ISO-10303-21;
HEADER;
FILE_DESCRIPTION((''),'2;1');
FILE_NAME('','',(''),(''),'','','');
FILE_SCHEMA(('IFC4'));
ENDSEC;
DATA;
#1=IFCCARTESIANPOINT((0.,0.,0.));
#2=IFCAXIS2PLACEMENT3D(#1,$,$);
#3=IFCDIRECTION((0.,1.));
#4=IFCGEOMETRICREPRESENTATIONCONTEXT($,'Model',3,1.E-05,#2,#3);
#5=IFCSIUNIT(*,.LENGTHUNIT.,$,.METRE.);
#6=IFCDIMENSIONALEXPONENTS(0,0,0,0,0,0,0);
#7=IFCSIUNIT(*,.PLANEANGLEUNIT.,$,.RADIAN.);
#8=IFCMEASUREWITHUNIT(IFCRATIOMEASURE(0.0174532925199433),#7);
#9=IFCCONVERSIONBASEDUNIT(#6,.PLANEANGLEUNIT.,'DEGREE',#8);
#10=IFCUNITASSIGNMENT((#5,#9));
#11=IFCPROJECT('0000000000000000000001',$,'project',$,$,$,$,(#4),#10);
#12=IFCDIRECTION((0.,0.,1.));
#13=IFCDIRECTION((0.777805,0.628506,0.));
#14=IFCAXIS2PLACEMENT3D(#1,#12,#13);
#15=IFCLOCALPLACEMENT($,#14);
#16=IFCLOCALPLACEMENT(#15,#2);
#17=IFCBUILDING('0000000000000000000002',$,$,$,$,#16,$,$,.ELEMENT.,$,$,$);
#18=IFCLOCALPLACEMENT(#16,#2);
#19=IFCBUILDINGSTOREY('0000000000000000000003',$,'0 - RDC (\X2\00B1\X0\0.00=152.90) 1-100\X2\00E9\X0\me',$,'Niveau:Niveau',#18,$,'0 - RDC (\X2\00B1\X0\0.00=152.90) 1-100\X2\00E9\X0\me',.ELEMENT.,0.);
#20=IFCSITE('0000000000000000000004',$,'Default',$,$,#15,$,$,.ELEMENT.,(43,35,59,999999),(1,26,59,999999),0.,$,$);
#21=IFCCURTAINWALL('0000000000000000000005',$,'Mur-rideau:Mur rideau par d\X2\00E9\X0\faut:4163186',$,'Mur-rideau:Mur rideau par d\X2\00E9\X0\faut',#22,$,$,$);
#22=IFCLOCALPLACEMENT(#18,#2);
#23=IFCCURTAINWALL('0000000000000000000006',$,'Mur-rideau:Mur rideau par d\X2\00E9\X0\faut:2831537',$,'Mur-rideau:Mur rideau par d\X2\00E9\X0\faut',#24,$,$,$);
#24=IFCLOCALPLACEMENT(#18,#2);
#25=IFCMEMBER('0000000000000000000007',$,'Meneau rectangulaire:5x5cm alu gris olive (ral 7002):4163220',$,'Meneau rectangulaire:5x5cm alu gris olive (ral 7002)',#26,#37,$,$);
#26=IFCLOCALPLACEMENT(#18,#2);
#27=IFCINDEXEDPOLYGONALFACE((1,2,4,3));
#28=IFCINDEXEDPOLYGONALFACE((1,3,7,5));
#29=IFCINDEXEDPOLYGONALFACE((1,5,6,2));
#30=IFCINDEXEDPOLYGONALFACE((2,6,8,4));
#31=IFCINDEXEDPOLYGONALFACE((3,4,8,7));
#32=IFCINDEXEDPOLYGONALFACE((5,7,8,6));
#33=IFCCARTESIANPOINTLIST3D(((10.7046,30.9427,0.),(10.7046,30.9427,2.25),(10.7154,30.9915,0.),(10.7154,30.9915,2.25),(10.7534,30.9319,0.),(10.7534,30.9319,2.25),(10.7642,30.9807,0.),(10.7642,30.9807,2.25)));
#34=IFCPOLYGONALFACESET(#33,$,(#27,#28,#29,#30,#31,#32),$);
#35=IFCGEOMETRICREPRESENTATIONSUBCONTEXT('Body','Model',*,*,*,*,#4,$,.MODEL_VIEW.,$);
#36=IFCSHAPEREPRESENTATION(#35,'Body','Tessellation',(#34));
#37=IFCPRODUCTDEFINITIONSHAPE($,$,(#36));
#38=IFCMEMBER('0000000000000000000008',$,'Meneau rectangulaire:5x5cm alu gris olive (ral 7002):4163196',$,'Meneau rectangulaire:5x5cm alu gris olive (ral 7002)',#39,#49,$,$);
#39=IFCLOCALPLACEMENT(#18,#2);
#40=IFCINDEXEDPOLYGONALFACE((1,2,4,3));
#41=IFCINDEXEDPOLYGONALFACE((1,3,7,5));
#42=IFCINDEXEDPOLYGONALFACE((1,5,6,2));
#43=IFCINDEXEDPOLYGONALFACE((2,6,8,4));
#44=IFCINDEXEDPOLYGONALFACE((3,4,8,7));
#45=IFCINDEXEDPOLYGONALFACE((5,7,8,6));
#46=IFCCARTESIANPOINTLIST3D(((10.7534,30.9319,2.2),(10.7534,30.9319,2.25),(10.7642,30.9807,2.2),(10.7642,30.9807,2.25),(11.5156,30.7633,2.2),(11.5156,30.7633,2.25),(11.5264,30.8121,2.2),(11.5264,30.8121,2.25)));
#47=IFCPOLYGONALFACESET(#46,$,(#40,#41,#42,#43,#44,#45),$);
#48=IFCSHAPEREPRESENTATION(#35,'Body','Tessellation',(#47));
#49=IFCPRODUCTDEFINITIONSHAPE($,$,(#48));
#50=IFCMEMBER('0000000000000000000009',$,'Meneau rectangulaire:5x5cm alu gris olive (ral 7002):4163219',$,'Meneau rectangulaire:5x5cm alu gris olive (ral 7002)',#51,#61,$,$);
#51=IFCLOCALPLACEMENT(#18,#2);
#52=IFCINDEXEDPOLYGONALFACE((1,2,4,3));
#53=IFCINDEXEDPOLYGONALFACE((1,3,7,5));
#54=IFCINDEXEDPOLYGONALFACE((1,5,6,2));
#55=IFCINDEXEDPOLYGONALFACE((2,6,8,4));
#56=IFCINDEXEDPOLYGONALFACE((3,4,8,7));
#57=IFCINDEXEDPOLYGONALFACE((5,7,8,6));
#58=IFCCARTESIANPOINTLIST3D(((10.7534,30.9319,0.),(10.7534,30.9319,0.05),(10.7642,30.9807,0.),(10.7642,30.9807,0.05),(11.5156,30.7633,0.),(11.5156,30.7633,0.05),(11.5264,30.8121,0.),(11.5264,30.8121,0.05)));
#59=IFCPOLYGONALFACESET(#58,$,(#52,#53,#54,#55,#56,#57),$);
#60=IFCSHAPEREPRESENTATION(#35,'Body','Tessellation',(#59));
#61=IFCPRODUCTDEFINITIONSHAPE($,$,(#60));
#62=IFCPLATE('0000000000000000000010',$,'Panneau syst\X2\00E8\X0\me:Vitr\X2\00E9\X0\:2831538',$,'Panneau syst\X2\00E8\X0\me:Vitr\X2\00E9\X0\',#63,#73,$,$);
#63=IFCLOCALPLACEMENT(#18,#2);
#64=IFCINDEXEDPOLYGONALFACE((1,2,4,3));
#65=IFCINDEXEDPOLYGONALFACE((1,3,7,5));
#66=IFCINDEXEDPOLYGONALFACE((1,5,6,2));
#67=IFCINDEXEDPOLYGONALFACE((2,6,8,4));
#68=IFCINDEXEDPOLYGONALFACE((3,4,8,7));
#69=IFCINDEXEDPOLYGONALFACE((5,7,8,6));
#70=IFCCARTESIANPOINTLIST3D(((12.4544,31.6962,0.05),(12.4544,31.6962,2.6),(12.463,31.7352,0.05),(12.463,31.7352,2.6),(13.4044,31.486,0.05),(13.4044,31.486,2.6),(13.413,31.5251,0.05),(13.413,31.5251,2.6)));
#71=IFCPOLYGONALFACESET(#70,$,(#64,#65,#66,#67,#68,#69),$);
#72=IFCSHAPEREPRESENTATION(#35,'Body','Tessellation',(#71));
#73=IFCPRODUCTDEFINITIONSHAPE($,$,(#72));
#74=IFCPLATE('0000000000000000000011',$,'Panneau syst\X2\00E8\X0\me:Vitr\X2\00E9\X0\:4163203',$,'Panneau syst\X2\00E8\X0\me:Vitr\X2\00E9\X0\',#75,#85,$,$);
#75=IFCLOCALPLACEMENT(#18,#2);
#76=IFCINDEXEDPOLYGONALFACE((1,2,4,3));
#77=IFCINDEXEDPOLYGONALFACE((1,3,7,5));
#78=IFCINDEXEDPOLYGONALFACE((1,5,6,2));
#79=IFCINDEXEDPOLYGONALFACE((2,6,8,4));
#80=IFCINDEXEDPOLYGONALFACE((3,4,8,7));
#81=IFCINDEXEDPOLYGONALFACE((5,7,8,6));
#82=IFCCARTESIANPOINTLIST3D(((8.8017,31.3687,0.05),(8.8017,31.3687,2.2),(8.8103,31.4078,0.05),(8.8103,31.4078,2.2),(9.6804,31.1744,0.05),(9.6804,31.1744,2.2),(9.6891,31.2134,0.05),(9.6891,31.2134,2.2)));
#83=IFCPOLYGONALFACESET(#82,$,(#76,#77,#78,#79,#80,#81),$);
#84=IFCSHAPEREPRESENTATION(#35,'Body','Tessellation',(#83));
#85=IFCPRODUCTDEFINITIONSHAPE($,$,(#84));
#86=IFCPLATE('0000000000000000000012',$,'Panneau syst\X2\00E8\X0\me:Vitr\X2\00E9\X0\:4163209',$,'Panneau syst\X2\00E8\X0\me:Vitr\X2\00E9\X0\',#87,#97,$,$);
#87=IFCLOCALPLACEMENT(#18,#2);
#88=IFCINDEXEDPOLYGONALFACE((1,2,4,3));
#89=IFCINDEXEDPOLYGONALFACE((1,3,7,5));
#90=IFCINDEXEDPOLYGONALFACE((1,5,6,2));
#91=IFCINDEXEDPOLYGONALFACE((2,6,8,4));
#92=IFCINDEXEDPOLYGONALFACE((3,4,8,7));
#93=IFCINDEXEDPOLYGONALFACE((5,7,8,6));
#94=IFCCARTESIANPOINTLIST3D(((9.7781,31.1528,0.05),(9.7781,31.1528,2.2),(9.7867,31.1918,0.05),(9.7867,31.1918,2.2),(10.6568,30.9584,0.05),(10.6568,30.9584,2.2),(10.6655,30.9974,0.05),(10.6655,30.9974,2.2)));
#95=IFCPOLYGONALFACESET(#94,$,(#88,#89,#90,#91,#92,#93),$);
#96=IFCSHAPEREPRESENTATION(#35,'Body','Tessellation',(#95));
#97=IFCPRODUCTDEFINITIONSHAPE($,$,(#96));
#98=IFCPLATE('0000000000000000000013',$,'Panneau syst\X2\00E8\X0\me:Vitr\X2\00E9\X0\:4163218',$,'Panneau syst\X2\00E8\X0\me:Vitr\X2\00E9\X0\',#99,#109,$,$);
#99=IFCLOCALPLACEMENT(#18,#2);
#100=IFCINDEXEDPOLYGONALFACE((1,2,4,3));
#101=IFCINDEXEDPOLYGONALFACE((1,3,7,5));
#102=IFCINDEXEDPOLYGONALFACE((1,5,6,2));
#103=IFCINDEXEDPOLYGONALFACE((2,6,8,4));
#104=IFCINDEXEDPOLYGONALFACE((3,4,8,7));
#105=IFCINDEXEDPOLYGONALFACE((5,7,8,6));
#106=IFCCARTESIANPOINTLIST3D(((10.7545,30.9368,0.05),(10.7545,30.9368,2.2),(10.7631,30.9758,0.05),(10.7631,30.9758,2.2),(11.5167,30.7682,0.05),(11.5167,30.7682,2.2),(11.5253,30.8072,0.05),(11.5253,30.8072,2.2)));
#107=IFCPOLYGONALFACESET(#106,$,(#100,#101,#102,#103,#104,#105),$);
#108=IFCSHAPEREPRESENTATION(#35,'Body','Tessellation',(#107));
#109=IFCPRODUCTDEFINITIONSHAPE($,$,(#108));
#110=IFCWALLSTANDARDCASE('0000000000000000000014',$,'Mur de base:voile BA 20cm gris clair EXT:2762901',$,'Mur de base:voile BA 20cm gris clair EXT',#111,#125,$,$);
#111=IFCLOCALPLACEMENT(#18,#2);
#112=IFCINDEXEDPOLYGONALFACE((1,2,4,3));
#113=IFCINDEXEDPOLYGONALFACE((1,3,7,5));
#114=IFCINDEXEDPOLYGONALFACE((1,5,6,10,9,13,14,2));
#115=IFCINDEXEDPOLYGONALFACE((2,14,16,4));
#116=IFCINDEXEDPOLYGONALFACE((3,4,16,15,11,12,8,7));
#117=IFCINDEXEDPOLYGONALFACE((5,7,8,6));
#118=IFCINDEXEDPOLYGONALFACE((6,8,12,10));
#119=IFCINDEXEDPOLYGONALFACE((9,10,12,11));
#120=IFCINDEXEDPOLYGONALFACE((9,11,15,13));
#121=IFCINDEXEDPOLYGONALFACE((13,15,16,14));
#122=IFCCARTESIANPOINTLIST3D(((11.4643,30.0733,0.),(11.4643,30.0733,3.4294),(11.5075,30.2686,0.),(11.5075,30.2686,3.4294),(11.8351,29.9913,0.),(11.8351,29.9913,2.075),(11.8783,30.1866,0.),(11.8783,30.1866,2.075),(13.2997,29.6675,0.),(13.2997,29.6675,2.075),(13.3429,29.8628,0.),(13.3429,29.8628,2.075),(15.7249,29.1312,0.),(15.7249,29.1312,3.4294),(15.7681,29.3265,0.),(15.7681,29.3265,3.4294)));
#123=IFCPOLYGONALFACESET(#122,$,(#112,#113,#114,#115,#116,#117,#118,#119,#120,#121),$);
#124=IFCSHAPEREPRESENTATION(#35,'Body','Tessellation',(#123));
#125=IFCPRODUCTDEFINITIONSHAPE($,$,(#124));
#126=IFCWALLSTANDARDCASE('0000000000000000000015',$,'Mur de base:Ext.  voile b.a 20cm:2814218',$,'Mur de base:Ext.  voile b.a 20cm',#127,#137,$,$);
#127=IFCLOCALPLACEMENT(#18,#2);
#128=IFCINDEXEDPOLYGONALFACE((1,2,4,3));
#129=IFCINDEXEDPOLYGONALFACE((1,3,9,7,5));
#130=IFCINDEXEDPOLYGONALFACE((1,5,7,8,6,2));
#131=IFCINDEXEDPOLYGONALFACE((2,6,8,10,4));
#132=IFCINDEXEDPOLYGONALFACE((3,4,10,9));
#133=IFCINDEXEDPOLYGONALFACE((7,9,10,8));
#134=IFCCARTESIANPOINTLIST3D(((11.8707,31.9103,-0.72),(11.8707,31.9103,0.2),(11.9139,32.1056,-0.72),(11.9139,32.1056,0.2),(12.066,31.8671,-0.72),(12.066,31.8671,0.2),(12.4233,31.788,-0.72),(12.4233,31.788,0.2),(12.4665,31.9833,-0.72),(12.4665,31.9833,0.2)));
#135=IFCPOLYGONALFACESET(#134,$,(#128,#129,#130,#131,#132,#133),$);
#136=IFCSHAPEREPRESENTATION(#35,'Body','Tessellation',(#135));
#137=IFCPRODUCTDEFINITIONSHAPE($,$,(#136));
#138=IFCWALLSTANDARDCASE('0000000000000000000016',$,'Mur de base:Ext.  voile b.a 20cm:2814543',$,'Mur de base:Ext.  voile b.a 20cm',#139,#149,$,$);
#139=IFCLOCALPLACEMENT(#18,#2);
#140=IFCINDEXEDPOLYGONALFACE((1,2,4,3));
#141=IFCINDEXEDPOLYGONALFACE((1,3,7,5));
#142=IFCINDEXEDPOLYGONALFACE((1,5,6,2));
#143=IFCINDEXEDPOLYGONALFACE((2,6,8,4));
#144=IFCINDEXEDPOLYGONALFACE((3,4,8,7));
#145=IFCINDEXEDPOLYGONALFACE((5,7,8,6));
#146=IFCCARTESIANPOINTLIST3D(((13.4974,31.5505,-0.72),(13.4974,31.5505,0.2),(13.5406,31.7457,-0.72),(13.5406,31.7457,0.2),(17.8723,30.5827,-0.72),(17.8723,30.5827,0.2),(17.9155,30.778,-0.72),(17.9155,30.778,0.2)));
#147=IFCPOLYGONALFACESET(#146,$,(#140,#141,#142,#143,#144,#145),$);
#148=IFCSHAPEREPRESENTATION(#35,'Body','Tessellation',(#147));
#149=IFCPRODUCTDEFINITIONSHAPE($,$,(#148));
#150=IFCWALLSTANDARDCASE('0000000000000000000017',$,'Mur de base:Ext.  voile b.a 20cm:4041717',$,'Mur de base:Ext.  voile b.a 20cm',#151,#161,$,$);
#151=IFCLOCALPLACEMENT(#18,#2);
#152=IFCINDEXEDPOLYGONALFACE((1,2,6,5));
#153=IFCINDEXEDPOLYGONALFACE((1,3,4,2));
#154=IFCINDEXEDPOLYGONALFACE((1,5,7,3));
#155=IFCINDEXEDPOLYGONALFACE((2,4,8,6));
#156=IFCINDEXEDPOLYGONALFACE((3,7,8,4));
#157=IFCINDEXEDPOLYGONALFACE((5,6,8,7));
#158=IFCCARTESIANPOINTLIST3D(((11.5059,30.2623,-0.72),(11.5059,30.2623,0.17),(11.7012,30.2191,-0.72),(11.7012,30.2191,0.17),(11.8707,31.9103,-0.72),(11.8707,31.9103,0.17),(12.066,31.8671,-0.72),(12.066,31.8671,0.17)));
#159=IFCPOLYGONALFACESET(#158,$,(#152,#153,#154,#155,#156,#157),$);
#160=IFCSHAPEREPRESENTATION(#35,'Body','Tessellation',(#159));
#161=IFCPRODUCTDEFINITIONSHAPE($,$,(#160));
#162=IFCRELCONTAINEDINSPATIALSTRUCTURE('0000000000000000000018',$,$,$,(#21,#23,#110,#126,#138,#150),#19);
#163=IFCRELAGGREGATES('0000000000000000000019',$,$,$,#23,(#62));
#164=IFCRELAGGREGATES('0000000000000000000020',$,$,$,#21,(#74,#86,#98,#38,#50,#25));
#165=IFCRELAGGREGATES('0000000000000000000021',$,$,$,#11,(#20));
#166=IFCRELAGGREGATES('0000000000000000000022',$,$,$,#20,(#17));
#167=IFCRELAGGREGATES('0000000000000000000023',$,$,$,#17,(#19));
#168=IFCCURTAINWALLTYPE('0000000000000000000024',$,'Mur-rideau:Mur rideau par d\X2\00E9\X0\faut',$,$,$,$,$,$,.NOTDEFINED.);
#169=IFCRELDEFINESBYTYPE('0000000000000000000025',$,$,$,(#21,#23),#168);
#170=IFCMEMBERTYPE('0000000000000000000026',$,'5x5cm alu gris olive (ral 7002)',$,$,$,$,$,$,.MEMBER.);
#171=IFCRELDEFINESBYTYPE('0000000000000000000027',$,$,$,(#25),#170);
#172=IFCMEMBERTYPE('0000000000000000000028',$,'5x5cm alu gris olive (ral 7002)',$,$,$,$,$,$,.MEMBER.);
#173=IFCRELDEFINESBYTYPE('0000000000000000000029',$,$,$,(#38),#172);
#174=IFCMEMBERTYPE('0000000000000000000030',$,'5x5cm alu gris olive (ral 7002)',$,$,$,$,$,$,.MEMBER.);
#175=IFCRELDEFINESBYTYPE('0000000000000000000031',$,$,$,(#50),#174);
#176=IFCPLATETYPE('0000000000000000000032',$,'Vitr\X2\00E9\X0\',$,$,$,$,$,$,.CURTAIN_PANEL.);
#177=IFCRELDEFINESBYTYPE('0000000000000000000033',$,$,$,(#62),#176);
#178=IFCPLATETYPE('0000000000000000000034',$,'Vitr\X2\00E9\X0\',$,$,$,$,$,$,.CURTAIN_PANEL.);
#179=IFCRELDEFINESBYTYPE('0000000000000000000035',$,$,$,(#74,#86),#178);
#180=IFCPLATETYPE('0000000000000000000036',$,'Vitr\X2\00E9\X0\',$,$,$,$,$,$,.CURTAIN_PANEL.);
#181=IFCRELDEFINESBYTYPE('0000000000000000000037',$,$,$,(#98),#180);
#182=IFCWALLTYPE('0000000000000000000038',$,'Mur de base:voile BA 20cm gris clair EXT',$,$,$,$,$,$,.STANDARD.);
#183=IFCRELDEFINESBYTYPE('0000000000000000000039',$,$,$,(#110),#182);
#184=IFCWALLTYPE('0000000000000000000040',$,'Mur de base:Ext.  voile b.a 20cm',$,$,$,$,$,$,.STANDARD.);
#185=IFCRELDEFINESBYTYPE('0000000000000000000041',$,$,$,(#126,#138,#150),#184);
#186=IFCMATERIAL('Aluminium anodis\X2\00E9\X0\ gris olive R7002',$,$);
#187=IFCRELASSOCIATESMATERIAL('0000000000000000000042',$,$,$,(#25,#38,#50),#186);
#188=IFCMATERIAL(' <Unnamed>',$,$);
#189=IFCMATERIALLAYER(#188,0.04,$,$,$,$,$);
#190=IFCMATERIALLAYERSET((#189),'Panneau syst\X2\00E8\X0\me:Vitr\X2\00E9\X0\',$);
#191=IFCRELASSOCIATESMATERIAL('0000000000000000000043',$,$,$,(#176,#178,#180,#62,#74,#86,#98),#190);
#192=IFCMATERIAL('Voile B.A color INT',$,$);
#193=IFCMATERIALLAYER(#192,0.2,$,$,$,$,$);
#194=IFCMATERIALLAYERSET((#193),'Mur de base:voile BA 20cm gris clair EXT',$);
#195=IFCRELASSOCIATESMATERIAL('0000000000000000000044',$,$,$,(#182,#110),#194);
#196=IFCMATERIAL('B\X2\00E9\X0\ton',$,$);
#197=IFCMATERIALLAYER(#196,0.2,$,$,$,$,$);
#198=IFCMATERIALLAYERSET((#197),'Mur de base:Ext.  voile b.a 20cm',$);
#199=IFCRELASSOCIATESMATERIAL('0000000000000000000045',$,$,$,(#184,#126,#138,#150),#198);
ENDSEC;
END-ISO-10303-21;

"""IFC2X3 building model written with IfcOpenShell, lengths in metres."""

from ifc_helpers import new_model, entity, si_unit, converted_unit, direction, frame, frame_2d, origin, origin_2d_with_axis, place, context, subcontext, project, spatial, polyline, rectangle, outline, extrude, source, transform, mapped, material, layer, layer_set, layer_usage, type_object, type_shapes, element, aggregate, save


model = new_model("IFC2X3")

# Units and contexts
model_context = context("Model", 3, precision=1e-05, world=origin(), true_north=direction((0.0, 1.0)))
body_context = subcontext(model_context, "Body", "Model", "MODEL_VIEW")
ifc_project = project(units=[si_unit("LENGTHUNIT", "METRE"), converted_unit("PLANEANGLEUNIT", "DEGREE", entity("IfcRatioMeasure", 0.0174532925199433), si_unit("PLANEANGLEUNIT", "RADIAN"), dimensions=[0, 0, 0, 0, 0, 0, 0])], contexts=[model_context])

# Site, building, storey
site_placement = place(None, frame((0.0, 0.0, 0.0), z_axis=(0.0, 0.0, 1.0), x_axis=(0.777805, 0.628506, 0.0)))
site = spatial("IfcSite", under=ifc_project, at=site_placement, Name="Default", CompositionType="ELEMENT", RefLatitude=(43, 35, 59, 999999), RefLongitude=(1, 26, 59, 999999), RefElevation=0.0)
building_placement = place(site_placement, origin())
building = spatial("IfcBuilding", under=site, at=building_placement, CompositionType="ELEMENT")
storey_placement = place(building_placement, origin())
storey = spatial("IfcBuildingStorey", under=building, at=storey_placement, Name="0 - RDC (±0.00=152.90) 1-100éme", ObjectType="Niveau:Niveau", LongName="0 - RDC (±0.00=152.90) 1-100éme", CompositionType="ELEMENT", Elevation=0.0)

# Curtain walls
curtain_wall_type = type_object("IfcCurtainWallType", Name="Mur-rideau:Mur rideau par défaut", PredefinedType="NOTDEFINED")
curtain_wall_1_placement = place(storey_placement, origin())
curtain_wall_1 = element("IfcCurtainWall", 1, at=curtain_wall_1_placement, inside=storey, type_object=curtain_wall_type, Name="Mur-rideau:Mur rideau par défaut:4163186", ObjectType="Mur-rideau:Mur rideau par défaut")
ifc_material_1 = material(Name="Aluminium anodisé gris olive R7002")
curtain_wall_2_placement = place(storey_placement, origin())
curtain_wall_2 = element("IfcCurtainWall", 2, at=curtain_wall_2_placement, inside=storey, type_object=curtain_wall_type, Name="Mur-rideau:Mur rideau par défaut:2831537", ObjectType="Mur-rideau:Mur rideau par défaut")

# Members
member_type_1 = type_object("IfcMemberType", Name="5x5cm alu gris olive (ral 7002)", PredefinedType="MEMBER")
shared_shape_1 = source(origin(), body_context, "Body", "SweptSolid", [
    extrude(rectangle(XDim=0.05, YDim=0.05, at=origin_2d_with_axis()), frame((0.0, 0.0, -2.25), z_axis=(0.0, 0.0, 1.0), x_axis=(0.0, -1.0, 0.0)), (0.0, 0.0, 1.0), 2.25),
])
type_shapes(member_type_1, [shared_shape_1])
member_1_placement = place(storey_placement, frame((10.7344, 30.9617, 0.0), z_axis=(0.0, 0.0, -1.0), x_axis=(0.976397, -0.215985, 0.0)))
member_1 = element("IfcMember", 3, at=member_1_placement, type_object=member_type_1, material=ifc_material_1, Name="Meneau rectangulaire:5x5cm alu gris olive (ral 7002):4163220", ObjectType="Meneau rectangulaire:5x5cm alu gris olive (ral 7002)", context=body_context, shape_type="MappedRepresentation", body=[
    mapped(shared_shape_1, transform((0.0, 0.0, 0.0), scale=1.0)),
])
member_type_2 = type_object("IfcMemberType", Name="5x5cm alu gris olive (ral 7002)", PredefinedType="MEMBER")
shared_shape_2 = source(origin(), body_context, "Body", "SweptSolid", [
    extrude(rectangle(XDim=0.05, YDim=0.05, at=origin_2d_with_axis()), frame((-0.025, 0.0, -0.7806), z_axis=(0.0, 0.0, 1.0), x_axis=(0.0, -1.0, 0.0)), (0.0, 0.0, 1.0), 0.7806),
])
type_shapes(member_type_2, [shared_shape_2])
member_2_placement = place(storey_placement, frame((11.521, 30.7877, 2.25), z_axis=(0.976397, -0.215985, 0.0), x_axis=(0.0, 0.0, 1.0)))
member_2 = element("IfcMember", 4, at=member_2_placement, type_object=member_type_2, material=ifc_material_1, Name="Meneau rectangulaire:5x5cm alu gris olive (ral 7002):4163196", ObjectType="Meneau rectangulaire:5x5cm alu gris olive (ral 7002)", context=body_context, shape_type="MappedRepresentation", body=[
    mapped(shared_shape_2, transform((0.0, 0.0, 0.0), scale=1.0)),
])
member_type_3 = type_object("IfcMemberType", Name="5x5cm alu gris olive (ral 7002)", PredefinedType="MEMBER")
shared_shape_3 = source(origin(), body_context, "Body", "SweptSolid", [
    extrude(rectangle(XDim=0.05, YDim=0.05, at=origin_2d_with_axis()), frame((-0.025, 0.0, -0.7806), z_axis=(0.0, 0.0, 1.0), x_axis=(0.0, -1.0, 0.0)), (0.0, 0.0, 1.0), 0.7806),
])
type_shapes(member_type_3, [shared_shape_3])
member_3_placement = place(storey_placement, frame((10.7588, 30.9563, 0.0), z_axis=(-0.976397, 0.215985, 0.0), x_axis=(0.0, 0.0, -1.0)))
member_3 = element("IfcMember", 5, at=member_3_placement, type_object=member_type_3, material=ifc_material_1, Name="Meneau rectangulaire:5x5cm alu gris olive (ral 7002):4163219", ObjectType="Meneau rectangulaire:5x5cm alu gris olive (ral 7002)", context=body_context, shape_type="MappedRepresentation", body=[
    mapped(shared_shape_3, transform((0.0, 0.0, 0.0), scale=1.0)),
])

# Plates
ifc_material_2 = material(Name=" <Unnamed>")
ifc_layer_1 = layer(ifc_material_2, 0.04)
ifc_layer_set_1 = layer_set([ifc_layer_1], Name="Panneau système:Vitré")
ifc_layer_usage_1 = layer_usage(ifc_layer_set_1, "AXIS3", "POSITIVE", 0.0)
plate_type_1 = type_object("IfcPlateType", Name="Vitré", PredefinedType="CURTAIN_PANEL", material=ifc_layer_set_1)
shared_shape_4 = source(origin(), body_context, "Body", "SweptSolid", [
    extrude(rectangle(XDim=0.04, YDim=0.9729, at=frame_2d((0.0, 0.0), x_axis=(1.0, 0.0))), frame((0.0, 0.0, 0.0), z_axis=(0.0, 0.0, 1.0), x_axis=(0.0, 1.0, 0.0)), (0.0, 0.0, 1.0), 2.55),
])
type_shapes(plate_type_1, [shared_shape_4])
plate_1_placement = place(curtain_wall_2_placement, frame((12.9337, 31.6106, 0.05), z_axis=(0.0, 0.0, 1.0), x_axis=(0.976397, -0.215985, 0.0)))
plate_1 = element("IfcPlate", 6, at=plate_1_placement, type_object=plate_type_1, material=ifc_layer_usage_1, Name="Panneau système:Vitré:2831538", ObjectType="Panneau système:Vitré", context=body_context, shape_type="MappedRepresentation", body=[
    mapped(shared_shape_4, transform((0.0, 0.0, 0.0), scale=1.0)),
])
aggregate(curtain_wall_2, [plate_1])
ifc_layer_usage_2 = layer_usage(ifc_layer_set_1, "AXIS3", "POSITIVE", 0.0)
plate_type_2 = type_object("IfcPlateType", Name="Vitré", PredefinedType="CURTAIN_PANEL", material=ifc_layer_set_1)
shared_shape_5 = source(origin(), body_context, "Body", "SweptSolid", [
    extrude(rectangle(XDim=0.04, YDim=0.9, at=frame_2d((0.0, 0.0), x_axis=(1.0, 0.0))), frame((0.0, 0.0, 0.0), z_axis=(0.0, 0.0, 1.0), x_axis=(0.0, 1.0, 0.0)), (0.0, 0.0, 1.0), 2.15),
])
type_shapes(plate_type_2, [shared_shape_5])
plate_2_placement = place(curtain_wall_1_placement, frame((9.2454, 31.2911, 0.05), z_axis=(0.0, 0.0, 1.0), x_axis=(0.976397, -0.215985, 0.0)))
plate_2 = element("IfcPlate", 7, at=plate_2_placement, type_object=plate_type_2, material=ifc_layer_usage_2, Name="Panneau système:Vitré:4163203", ObjectType="Panneau système:Vitré", context=body_context, shape_type="MappedRepresentation", body=[
    mapped(shared_shape_5, transform((0.0, 0.0, 0.0), scale=1.0)),
])
ifc_layer_usage_3 = layer_usage(ifc_layer_set_1, "AXIS3", "POSITIVE", 0.0)
plate_3_placement = place(curtain_wall_1_placement, frame((10.2218, 31.0751, 0.05), z_axis=(0.0, 0.0, 1.0), x_axis=(0.976397, -0.215985, 0.0)))
plate_3 = element("IfcPlate", 8, at=plate_3_placement, type_object=plate_type_2, material=ifc_layer_usage_3, Name="Panneau système:Vitré:4163209", ObjectType="Panneau système:Vitré", context=body_context, shape_type="MappedRepresentation", body=[
    mapped(shared_shape_5, transform((0.0, 0.0, 0.0), scale=1.0)),
])
ifc_layer_usage_4 = layer_usage(ifc_layer_set_1, "AXIS3", "POSITIVE", 0.0)
plate_type_3 = type_object("IfcPlateType", Name="Vitré", PredefinedType="CURTAIN_PANEL", material=ifc_layer_set_1)
shared_shape_6 = source(origin(), body_context, "Body", "SweptSolid", [
    extrude(rectangle(XDim=0.04, YDim=0.7806, at=frame_2d((0.0, 0.0), x_axis=(1.0, 0.0))), frame((0.0, 0.0, 0.0), z_axis=(0.0, 0.0, 1.0), x_axis=(0.0, 1.0, 0.0)), (0.0, 0.0, 1.0), 2.15),
])
type_shapes(plate_type_3, [shared_shape_6])
plate_4_placement = place(curtain_wall_1_placement, frame((11.1399, 30.872, 0.05), z_axis=(0.0, 0.0, 1.0), x_axis=(0.976397, -0.215985, 0.0)))
plate_4 = element("IfcPlate", 9, at=plate_4_placement, type_object=plate_type_3, material=ifc_layer_usage_4, Name="Panneau système:Vitré:4163218", ObjectType="Panneau système:Vitré", context=body_context, shape_type="MappedRepresentation", body=[
    mapped(shared_shape_6, transform((0.0, 0.0, 0.0), scale=1.0)),
])
aggregate(curtain_wall_1, [plate_2, plate_3, plate_4, member_2, member_3, member_1])

# Wall, opening
ifc_material_3 = material(Name="Voile B.A color INT")
ifc_layer_2 = layer(ifc_material_3, 0.2)
ifc_layer_set_2 = layer_set([ifc_layer_2], Name="Mur de base:voile BA 20cm gris clair EXT")
ifc_layer_usage_5 = layer_usage(ifc_layer_set_2, "AXIS2", "NEGATIVE", 0.1)
wall_type_1 = type_object("IfcWallType", Name="Mur de base:voile BA 20cm gris clair EXT", PredefinedType="STANDARD", material=ifc_layer_set_2)
wall_1_placement = place(storey_placement, frame((11.4859, 30.171, 0.0), z_axis=(0.0, 0.0, 1.0), x_axis=(0.976415, -0.2159, 0.0)))
wall_1 = element("IfcWallStandardCase", 10, at=wall_1_placement, inside=storey, type_object=wall_type_1, material=ifc_layer_usage_5, Name="Mur de base:voile BA 20cm gris clair EXT:2762901", ObjectType="Mur de base:voile BA 20cm gris clair EXT", context=body_context, shape_type="SweptSolid", body=[
    extrude(outline(polyline([(0.0, -0.1), (4.1635, -0.1), (4.3635, -0.1), (4.3635, 0.0893), (4.3635, 0.1), (0.0, 0.1), (0.0, -0.1)])), origin(), (0.0, 0.0, 1.0), 3.4294),
])
opening_placement = place(wall_1_placement, frame((1.8798, 0.1, 0.0)))
element("IfcOpeningElement", 11, at=opening_placement, cuts=wall_1, ObjectType="Opening", context=body_context, shape_type="SweptSolid", body=[
    extrude(rectangle(XDim=2.075, YDim=1.5, at=frame_2d((1.0375, 0.75), x_axis=(1.0, 0.0))), frame((0.0, 0.0, 0.0), z_axis=(0.0, -1.0, 0.0), x_axis=(0.0, 0.0, 1.0)), (0.0, 0.0, 1.0), 0.2),
])

# Walls
ifc_material_4 = material(Name="Béton")
ifc_layer_3 = layer(ifc_material_4, 0.2)
ifc_layer_set_3 = layer_set([ifc_layer_3], Name="Mur de base:Ext.  voile b.a 20cm")
ifc_layer_usage_6 = layer_usage(ifc_layer_set_3, "AXIS2", "NEGATIVE", 0.1)
wall_type_2 = type_object("IfcWallType", Name="Mur de base:Ext.  voile b.a 20cm", PredefinedType="STANDARD", material=ifc_layer_set_3)
wall_2_placement = place(storey_placement, frame((11.8923, 32.0079, -0.72), z_axis=(0.0, 0.0, 1.0), x_axis=(0.976397, -0.215985, 0.0)))
element("IfcWallStandardCase", 12, at=wall_2_placement, inside=storey, type_object=wall_type_2, material=ifc_layer_usage_6, Name="Mur de base:Ext.  voile b.a 20cm:2814218", ObjectType="Mur de base:Ext.  voile b.a 20cm", context=body_context, shape_type="SweptSolid", body=[
    extrude(outline(polyline([(0.566, -0.1), (0.566, 0.1), (0.0, 0.1), (0.0, -0.1), (0.2, -0.1), (0.566, -0.1)])), origin(), (0.0, 0.0, 1.0), 0.92),
])
ifc_layer_usage_7 = layer_usage(ifc_layer_set_3, "AXIS2", "NEGATIVE", 0.1)
wall_3_placement = place(storey_placement, frame((13.519, 31.6481, -0.72), z_axis=(0.0, 0.0, 1.0), x_axis=(0.976397, -0.215985, 0.0)))
element("IfcWallStandardCase", 13, at=wall_3_placement, inside=storey, type_object=wall_type_2, material=ifc_layer_usage_7, Name="Mur de base:Ext.  voile b.a 20cm:2814543", ObjectType="Mur de base:Ext.  voile b.a 20cm", context=body_context, shape_type="SweptSolid", body=[
    extrude(rectangle(XDim=4.4807, YDim=0.2, at=frame_2d((2.2403, 0.0), x_axis=(-1.0, 0.0))), origin(), (0.0, 0.0, 1.0), 0.92),
])
ifc_layer_usage_8 = layer_usage(ifc_layer_set_3, "AXIS2", "NEGATIVE", 0.1)
wall_4_placement = place(storey_placement, frame((11.6036, 30.2407, -0.72), z_axis=(0.0, 0.0, 1.0), x_axis=(0.216109, 0.976369, 0.0)))
element("IfcWallStandardCase", 14, at=wall_4_placement, inside=storey, type_object=wall_type_2, material=ifc_layer_usage_8, Name="Mur de base:Ext.  voile b.a 20cm:4041717", ObjectType="Mur de base:Ext.  voile b.a 20cm", context=body_context, shape_type="SweptSolid", body=[
    extrude(outline(polyline([(1.6879, -0.1), (1.6879, 0.1), (0.0, 0.1), (0.0, -0.1), (1.6879, -0.1)])), origin(), (0.0, 0.0, 1.0), 0.89),
])

save(model, "model.ifc")
